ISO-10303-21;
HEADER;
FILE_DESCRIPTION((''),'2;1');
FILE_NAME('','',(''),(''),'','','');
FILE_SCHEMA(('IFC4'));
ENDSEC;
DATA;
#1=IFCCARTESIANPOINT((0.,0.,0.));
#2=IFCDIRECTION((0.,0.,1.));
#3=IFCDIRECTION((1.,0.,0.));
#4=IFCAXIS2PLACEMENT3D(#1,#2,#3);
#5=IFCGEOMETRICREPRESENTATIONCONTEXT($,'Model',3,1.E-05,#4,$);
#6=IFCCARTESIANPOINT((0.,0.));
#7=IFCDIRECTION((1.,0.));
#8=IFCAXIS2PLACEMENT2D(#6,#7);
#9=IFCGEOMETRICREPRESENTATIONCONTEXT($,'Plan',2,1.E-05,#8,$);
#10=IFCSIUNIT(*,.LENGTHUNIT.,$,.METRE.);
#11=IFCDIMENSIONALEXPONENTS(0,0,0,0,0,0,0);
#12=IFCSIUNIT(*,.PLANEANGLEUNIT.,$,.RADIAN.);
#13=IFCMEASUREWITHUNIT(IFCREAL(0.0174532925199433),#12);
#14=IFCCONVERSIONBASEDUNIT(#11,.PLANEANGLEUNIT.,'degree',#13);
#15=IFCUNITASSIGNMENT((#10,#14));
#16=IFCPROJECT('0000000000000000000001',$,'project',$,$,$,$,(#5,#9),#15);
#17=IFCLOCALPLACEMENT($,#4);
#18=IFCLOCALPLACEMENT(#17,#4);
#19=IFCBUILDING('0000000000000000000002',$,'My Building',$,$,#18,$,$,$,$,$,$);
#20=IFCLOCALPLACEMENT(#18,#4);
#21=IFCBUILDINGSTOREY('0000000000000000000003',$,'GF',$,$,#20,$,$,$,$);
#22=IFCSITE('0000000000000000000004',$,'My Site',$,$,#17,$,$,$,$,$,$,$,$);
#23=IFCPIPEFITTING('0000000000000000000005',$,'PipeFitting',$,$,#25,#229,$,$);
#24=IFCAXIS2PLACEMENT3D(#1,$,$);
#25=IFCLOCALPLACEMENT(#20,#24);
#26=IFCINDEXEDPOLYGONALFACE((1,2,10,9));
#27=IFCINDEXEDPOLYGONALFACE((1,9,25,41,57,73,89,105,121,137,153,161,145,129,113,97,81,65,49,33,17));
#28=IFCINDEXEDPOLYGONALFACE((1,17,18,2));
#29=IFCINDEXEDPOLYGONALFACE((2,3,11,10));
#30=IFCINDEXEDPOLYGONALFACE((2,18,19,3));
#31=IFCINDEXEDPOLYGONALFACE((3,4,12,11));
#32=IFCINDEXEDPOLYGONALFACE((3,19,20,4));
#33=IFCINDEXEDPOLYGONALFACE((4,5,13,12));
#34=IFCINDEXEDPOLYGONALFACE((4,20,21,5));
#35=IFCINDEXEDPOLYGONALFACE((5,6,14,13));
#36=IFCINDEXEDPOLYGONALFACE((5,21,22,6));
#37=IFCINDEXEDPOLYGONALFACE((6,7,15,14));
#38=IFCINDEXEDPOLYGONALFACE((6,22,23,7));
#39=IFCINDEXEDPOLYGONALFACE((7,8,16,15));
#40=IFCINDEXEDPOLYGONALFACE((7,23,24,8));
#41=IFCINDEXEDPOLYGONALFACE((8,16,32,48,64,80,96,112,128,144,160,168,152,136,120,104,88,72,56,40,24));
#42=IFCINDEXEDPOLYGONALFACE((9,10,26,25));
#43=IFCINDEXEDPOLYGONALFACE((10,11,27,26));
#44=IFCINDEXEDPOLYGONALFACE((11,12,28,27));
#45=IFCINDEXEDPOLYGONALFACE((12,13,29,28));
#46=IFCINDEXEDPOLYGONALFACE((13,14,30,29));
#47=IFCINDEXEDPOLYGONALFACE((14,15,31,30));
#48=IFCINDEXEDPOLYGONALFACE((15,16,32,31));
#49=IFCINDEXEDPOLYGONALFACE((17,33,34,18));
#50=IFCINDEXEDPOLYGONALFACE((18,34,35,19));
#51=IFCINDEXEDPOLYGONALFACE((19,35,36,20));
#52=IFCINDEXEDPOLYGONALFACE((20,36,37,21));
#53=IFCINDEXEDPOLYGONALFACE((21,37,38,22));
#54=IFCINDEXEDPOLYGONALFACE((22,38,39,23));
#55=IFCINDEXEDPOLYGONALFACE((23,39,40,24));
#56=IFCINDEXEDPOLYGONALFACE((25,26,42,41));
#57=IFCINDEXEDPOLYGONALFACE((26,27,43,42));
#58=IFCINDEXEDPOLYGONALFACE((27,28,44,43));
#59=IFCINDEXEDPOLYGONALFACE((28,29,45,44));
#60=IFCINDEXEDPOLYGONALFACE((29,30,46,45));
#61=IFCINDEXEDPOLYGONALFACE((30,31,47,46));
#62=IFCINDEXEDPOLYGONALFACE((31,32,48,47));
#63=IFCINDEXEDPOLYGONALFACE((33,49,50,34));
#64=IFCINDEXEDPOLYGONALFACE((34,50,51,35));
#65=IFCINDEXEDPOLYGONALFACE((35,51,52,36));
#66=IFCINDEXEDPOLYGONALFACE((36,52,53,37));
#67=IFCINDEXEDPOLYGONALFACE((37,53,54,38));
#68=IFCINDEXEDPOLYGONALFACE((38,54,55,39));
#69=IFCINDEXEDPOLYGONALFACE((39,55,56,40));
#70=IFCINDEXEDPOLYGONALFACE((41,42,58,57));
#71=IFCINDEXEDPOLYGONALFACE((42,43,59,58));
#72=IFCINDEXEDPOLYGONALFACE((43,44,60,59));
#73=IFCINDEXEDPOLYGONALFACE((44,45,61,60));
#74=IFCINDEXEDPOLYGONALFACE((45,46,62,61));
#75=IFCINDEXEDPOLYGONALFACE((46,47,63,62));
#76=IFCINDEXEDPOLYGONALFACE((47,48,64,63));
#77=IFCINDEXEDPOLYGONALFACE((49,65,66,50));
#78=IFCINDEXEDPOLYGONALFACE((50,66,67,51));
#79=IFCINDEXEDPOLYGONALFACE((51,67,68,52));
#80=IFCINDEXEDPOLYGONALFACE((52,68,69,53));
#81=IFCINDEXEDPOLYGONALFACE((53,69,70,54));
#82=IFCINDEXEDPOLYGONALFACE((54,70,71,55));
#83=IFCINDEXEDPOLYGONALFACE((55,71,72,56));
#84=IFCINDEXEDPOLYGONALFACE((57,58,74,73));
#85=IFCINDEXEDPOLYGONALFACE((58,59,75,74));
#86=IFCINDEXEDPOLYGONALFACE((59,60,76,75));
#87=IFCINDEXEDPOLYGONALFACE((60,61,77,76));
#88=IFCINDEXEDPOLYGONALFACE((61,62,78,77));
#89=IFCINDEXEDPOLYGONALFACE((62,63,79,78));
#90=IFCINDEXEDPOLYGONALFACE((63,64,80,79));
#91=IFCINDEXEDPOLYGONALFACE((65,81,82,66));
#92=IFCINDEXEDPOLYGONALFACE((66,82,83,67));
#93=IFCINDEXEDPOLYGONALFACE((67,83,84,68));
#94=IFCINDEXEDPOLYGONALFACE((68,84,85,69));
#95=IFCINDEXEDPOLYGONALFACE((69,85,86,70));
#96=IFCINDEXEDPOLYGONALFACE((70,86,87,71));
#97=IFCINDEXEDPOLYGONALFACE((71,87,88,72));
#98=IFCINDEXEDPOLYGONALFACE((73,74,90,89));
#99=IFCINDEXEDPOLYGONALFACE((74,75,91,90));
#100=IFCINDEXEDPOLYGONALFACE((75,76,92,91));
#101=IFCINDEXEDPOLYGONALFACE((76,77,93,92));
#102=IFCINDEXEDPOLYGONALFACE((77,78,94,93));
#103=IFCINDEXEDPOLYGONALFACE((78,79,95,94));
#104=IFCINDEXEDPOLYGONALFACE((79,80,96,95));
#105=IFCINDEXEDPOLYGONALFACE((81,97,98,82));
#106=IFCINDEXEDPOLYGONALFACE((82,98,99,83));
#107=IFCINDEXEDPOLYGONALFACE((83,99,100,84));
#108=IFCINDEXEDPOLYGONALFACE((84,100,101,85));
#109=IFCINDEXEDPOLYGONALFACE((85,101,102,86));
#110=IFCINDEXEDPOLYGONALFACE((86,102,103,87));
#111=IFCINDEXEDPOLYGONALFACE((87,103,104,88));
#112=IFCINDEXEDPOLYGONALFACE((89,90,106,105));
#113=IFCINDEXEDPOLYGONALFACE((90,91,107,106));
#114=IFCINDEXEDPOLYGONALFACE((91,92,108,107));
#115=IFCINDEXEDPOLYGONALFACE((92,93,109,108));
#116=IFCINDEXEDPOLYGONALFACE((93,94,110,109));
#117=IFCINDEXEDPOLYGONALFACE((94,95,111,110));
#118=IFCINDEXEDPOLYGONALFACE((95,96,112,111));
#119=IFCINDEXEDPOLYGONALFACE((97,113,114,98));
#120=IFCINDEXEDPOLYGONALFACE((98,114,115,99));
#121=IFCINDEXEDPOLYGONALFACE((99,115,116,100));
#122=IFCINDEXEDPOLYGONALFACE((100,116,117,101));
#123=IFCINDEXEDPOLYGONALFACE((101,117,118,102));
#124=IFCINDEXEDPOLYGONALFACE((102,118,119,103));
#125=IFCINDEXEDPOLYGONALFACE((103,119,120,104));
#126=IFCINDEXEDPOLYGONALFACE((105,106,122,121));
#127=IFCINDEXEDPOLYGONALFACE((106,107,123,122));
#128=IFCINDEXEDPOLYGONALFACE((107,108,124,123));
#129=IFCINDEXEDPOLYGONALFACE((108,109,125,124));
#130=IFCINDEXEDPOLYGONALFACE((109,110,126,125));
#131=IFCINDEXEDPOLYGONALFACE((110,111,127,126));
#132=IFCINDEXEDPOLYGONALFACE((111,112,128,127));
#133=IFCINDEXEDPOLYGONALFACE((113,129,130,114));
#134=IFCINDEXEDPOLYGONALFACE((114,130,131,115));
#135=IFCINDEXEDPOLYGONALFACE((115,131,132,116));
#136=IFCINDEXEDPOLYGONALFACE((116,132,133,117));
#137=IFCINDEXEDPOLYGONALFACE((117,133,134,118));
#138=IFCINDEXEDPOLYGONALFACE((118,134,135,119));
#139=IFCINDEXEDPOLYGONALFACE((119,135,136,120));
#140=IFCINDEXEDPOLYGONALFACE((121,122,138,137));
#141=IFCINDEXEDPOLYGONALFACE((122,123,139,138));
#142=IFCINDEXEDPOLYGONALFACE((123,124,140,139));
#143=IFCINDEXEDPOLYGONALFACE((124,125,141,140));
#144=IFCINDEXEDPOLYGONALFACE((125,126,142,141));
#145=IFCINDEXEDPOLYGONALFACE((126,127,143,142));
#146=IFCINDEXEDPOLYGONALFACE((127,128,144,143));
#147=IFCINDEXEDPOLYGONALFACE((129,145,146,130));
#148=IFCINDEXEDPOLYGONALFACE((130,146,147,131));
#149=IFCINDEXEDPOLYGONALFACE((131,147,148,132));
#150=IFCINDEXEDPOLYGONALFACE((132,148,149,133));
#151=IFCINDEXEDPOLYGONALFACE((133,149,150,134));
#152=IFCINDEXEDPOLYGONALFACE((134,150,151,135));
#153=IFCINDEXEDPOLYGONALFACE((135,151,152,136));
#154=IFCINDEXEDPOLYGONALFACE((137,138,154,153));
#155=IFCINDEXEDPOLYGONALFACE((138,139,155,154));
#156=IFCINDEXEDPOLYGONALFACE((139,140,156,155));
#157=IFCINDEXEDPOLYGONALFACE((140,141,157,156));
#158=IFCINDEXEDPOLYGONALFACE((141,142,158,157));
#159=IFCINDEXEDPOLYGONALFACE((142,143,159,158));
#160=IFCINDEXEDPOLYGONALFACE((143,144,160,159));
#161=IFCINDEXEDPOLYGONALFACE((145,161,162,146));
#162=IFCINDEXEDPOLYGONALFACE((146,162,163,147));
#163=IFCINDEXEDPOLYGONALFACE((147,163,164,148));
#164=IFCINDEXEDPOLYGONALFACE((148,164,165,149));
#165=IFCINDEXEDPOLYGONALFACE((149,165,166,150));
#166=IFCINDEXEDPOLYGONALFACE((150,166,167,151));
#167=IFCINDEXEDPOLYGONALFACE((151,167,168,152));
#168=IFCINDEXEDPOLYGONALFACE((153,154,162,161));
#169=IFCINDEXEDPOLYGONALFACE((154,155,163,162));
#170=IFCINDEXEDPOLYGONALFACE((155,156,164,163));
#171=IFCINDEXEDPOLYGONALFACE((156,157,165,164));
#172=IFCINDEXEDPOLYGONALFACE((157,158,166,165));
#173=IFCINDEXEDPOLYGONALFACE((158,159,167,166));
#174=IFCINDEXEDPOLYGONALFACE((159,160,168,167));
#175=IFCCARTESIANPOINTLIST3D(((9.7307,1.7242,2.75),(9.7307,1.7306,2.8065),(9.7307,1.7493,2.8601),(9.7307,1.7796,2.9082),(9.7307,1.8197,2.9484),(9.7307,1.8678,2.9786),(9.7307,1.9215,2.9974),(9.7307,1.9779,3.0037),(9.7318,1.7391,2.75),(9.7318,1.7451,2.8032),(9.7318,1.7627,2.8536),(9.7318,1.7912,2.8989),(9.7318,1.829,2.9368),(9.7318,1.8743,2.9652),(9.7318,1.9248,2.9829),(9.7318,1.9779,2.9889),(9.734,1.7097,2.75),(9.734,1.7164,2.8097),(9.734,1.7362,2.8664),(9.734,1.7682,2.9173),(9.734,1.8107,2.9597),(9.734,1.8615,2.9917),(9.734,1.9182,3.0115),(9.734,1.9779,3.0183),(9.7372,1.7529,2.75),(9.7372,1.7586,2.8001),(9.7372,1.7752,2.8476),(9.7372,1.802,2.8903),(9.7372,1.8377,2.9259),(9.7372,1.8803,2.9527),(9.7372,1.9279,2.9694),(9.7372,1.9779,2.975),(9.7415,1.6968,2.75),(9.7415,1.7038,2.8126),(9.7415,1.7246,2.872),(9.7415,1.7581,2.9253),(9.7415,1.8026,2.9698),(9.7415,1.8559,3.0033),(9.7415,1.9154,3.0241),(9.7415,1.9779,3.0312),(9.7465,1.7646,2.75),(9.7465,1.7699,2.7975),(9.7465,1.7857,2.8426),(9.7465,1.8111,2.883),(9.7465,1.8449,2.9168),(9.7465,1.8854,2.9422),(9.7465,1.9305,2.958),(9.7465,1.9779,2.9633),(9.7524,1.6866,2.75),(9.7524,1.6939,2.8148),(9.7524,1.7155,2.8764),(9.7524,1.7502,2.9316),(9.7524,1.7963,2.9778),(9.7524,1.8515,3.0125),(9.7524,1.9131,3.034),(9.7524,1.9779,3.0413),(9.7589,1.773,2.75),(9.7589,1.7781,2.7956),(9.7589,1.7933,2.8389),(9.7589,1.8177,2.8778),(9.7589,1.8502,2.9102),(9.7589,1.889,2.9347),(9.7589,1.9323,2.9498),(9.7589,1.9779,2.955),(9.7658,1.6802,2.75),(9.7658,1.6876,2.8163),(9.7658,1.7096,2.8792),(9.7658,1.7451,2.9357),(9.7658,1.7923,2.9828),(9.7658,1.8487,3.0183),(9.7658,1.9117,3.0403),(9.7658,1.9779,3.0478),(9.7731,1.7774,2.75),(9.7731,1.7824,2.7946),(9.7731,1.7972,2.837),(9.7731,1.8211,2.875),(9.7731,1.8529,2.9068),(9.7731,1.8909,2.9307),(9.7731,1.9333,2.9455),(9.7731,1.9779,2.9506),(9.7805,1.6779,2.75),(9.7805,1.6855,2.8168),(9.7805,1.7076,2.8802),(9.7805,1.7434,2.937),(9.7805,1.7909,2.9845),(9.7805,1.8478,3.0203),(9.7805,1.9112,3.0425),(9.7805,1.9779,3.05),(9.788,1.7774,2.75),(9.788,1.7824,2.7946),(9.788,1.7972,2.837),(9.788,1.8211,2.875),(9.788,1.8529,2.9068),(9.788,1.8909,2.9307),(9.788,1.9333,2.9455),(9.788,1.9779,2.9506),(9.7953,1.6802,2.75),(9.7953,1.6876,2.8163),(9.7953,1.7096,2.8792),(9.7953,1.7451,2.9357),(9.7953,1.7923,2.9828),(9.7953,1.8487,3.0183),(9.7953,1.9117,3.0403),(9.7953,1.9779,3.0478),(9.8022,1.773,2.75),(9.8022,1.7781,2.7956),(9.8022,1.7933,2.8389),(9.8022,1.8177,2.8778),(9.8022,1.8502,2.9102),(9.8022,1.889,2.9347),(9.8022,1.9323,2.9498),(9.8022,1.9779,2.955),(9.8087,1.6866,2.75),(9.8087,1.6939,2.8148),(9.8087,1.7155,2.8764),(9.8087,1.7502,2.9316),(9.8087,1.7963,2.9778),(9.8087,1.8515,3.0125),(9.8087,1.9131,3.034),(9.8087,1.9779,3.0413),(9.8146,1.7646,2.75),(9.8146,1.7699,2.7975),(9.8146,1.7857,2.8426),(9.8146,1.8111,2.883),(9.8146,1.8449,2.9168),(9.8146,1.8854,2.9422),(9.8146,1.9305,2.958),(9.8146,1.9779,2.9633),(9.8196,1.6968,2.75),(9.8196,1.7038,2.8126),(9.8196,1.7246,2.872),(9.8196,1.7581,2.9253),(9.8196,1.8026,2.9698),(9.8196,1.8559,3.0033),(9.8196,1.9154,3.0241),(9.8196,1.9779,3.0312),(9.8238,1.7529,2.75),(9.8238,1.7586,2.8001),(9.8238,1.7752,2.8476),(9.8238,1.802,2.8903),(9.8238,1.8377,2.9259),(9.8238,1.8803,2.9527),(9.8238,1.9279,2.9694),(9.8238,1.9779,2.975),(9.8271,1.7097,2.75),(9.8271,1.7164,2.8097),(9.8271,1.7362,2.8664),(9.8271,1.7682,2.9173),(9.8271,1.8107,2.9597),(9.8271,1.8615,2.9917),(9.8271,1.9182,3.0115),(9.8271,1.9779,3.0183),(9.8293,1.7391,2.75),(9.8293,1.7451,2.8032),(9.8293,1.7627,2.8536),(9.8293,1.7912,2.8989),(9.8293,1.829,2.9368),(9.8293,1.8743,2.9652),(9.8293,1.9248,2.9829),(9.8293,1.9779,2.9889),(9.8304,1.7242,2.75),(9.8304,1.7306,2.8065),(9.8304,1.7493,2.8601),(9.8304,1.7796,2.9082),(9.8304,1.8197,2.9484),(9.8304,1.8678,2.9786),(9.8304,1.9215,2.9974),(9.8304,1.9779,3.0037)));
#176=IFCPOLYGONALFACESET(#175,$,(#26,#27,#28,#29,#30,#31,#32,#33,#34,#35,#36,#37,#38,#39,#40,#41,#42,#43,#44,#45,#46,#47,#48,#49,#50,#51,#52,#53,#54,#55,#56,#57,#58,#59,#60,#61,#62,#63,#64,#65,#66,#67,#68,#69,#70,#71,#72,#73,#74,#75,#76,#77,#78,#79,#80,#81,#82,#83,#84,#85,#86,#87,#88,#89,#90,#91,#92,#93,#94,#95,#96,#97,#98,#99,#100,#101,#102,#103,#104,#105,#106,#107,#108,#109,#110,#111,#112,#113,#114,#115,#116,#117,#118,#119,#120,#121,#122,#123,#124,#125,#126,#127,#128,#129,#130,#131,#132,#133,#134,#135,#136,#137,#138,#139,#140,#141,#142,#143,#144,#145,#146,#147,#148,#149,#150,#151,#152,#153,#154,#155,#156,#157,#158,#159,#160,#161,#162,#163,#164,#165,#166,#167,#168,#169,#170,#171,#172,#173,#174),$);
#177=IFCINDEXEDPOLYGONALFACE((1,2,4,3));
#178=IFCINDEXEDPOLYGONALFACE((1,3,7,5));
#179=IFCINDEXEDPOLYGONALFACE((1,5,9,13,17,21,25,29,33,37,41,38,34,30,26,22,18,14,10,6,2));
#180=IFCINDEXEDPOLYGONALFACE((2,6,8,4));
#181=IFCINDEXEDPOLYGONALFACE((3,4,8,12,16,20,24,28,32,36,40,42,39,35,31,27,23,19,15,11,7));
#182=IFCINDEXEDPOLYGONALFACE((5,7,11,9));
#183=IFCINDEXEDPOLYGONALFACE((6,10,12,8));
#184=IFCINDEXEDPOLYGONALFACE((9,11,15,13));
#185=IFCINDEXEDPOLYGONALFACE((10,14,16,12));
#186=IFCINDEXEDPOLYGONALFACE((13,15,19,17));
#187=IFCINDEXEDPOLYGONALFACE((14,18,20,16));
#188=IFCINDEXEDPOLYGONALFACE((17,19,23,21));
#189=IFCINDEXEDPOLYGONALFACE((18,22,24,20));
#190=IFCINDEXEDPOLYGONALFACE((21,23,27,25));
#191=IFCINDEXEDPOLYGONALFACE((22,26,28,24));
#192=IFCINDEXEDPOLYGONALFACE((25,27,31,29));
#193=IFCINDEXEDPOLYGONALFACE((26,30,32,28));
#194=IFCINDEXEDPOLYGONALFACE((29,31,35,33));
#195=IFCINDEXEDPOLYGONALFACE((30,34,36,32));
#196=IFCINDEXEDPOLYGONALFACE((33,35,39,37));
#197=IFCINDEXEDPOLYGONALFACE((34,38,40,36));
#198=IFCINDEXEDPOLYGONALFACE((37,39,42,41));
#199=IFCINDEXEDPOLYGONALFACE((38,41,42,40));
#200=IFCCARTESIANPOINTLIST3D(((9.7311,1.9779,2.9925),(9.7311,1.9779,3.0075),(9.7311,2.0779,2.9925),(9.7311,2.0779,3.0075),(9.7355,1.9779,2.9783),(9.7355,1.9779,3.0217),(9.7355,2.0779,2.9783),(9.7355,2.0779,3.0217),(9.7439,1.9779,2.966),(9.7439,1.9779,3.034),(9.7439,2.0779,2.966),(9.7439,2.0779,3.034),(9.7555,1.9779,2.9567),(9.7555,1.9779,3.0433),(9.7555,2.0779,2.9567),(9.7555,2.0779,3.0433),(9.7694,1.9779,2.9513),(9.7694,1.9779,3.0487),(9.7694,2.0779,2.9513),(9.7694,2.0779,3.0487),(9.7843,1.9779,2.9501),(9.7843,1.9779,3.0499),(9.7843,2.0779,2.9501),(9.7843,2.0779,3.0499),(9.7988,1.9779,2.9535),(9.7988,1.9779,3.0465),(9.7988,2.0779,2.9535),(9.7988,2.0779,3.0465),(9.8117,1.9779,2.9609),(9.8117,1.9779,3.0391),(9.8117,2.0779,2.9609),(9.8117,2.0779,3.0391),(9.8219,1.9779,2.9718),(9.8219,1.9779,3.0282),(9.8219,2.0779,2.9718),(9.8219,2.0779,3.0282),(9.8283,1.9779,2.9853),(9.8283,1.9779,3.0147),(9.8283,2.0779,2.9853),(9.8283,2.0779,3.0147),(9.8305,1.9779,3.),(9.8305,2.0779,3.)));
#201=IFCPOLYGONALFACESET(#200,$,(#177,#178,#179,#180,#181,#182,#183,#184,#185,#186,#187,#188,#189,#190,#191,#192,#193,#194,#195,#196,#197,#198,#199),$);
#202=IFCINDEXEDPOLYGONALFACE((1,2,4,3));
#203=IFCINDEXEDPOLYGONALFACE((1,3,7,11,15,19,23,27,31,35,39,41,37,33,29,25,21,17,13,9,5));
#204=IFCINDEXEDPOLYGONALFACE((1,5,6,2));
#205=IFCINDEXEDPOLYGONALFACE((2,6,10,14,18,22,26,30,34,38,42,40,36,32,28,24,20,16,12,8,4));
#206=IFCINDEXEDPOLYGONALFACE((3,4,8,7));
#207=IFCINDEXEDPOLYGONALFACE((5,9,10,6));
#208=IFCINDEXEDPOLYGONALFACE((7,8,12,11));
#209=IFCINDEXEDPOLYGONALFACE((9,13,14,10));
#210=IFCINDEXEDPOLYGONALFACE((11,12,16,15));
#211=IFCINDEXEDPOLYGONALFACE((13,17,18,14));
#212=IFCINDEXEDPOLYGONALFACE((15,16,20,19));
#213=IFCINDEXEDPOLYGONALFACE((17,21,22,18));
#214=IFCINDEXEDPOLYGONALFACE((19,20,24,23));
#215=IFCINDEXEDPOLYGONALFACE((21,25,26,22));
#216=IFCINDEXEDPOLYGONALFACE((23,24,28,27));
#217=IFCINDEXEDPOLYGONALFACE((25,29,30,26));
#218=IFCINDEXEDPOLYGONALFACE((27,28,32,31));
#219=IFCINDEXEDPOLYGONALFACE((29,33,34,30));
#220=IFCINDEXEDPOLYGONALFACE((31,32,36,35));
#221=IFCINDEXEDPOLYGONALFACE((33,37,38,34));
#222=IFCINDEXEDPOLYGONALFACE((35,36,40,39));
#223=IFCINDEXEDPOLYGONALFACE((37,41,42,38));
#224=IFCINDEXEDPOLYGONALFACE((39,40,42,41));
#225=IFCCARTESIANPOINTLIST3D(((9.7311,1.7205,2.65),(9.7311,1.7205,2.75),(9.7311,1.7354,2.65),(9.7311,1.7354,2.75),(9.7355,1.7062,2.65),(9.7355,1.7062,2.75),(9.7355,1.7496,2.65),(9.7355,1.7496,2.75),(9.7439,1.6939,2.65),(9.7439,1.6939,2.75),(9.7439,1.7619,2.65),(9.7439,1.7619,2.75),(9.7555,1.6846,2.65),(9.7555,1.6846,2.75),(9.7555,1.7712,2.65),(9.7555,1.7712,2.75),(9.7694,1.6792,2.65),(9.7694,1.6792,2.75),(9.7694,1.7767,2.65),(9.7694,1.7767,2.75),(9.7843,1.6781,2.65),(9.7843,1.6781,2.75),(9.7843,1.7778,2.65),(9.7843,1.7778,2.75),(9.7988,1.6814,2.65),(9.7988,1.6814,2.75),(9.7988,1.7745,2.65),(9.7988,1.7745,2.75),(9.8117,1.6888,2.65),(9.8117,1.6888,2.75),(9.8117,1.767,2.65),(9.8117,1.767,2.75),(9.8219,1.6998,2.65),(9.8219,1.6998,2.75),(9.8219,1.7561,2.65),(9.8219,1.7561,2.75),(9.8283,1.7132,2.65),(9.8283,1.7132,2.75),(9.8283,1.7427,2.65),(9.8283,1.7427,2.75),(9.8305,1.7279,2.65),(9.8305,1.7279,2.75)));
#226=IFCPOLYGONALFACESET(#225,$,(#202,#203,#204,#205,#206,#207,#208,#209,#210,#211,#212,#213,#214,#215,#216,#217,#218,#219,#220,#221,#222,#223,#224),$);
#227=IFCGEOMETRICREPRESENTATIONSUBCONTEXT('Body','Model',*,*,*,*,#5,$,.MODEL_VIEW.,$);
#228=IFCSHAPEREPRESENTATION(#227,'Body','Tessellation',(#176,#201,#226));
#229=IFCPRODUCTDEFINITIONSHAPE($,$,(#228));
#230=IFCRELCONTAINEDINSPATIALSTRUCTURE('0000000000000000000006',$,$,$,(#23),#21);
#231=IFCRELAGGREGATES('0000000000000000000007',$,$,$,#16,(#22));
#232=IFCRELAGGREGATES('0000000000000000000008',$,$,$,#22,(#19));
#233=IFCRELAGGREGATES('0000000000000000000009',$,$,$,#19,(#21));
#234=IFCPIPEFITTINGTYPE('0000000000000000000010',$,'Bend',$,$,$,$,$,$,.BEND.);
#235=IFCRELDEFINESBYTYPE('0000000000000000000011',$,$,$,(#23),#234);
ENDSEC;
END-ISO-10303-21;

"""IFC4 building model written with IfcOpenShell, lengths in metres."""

from ifc_helpers import new_model, entity, si_unit, converted_unit, frame, origin_with_axes, origin_2d_with_axis, place, context, subcontext, project, spatial, circle, extrude, source, transform, mapped, type_object, type_shapes, element, save


model = new_model("IFC4")

# Units and contexts
model_context = context("Model", 3, precision=1e-05, world=origin_with_axes())
plan_context = context("Plan", 2, precision=1e-05, world=origin_2d_with_axis())
body_context_1 = subcontext(model_context, "Body", "Model", "MODEL_VIEW")
ifc_project = project(units=[si_unit("LENGTHUNIT", "METRE"), converted_unit("PLANEANGLEUNIT", "degree", entity("IfcReal", 0.0174532925199433), si_unit("PLANEANGLEUNIT", "RADIAN"), dimensions=[0, 0, 0, 0, 0, 0, 0])], contexts=[model_context, plan_context])

# Site, building, storey
site_placement = place(None, origin_with_axes())
site = spatial("IfcSite", under=ifc_project, at=site_placement, Name="My Site")
building_placement = place(site_placement, origin_with_axes())
building = spatial("IfcBuilding", under=site, at=building_placement, Name="My Building")
storey_placement = place(building_placement, origin_with_axes())
storey = spatial("IfcBuildingStorey", under=building, at=storey_placement, Name="GF")

# Pipe fitting
pipe_fitting_type = type_object("IfcPipeFittingType", Name="Bend", PredefinedType="BEND")
shared_shape_1 = source(origin_with_axes(), body_context_1, "Body", "SolidModel", [
    entity("IfcSweptDiskSolid", entity("IfcIndexedPolyCurve", entity("IfcCartesianPointList3D", [[0.0, 0.0, 0.1], [0.0, -0.0732, 0.2768], [0.0, -0.25, 0.35]]), [entity("IfcArcIndex", [1, 2, 3])]), 0.05),
    extrude(circle(Radius=0.05), origin_with_axes(), (0.0, 0.0, 1.0), 0.1),
    extrude(circle(Radius=0.05), frame((0.0, -0.25, 0.35), z_axis=(0.0, -1.0, 0.0), x_axis=(1.0, 0.0, 0.0)), (0.0, 0.0, 1.0), 0.1),
])
type_shapes(pipe_fitting_type, [shared_shape_1])
for number, where, z_axis, x_axis, name in (
    (1, (9.7805, 2.0779, 3.0), (0.0, -1.0, 0.0), (1.0, 0.0, 0.0), "PipeFitting"),
):
    element("IfcPipeFitting", number, at=place(storey_placement, frame(where, z_axis=z_axis, x_axis=x_axis)), inside=storey, type_object=pipe_fitting_type, Name=name, context=body_context_1, shape_type="MappedRepresentation", body=[
        mapped(shared_shape_1, transform((0.0, 0.0, 0.0), x_axis=(1.0, 0.0, 0.0), y_axis=(0.0, 1.0, 0.0), z_axis=(0.0, 0.0, 1.0), scale=1.0)),
    ])

save(model, "model.ifc")
